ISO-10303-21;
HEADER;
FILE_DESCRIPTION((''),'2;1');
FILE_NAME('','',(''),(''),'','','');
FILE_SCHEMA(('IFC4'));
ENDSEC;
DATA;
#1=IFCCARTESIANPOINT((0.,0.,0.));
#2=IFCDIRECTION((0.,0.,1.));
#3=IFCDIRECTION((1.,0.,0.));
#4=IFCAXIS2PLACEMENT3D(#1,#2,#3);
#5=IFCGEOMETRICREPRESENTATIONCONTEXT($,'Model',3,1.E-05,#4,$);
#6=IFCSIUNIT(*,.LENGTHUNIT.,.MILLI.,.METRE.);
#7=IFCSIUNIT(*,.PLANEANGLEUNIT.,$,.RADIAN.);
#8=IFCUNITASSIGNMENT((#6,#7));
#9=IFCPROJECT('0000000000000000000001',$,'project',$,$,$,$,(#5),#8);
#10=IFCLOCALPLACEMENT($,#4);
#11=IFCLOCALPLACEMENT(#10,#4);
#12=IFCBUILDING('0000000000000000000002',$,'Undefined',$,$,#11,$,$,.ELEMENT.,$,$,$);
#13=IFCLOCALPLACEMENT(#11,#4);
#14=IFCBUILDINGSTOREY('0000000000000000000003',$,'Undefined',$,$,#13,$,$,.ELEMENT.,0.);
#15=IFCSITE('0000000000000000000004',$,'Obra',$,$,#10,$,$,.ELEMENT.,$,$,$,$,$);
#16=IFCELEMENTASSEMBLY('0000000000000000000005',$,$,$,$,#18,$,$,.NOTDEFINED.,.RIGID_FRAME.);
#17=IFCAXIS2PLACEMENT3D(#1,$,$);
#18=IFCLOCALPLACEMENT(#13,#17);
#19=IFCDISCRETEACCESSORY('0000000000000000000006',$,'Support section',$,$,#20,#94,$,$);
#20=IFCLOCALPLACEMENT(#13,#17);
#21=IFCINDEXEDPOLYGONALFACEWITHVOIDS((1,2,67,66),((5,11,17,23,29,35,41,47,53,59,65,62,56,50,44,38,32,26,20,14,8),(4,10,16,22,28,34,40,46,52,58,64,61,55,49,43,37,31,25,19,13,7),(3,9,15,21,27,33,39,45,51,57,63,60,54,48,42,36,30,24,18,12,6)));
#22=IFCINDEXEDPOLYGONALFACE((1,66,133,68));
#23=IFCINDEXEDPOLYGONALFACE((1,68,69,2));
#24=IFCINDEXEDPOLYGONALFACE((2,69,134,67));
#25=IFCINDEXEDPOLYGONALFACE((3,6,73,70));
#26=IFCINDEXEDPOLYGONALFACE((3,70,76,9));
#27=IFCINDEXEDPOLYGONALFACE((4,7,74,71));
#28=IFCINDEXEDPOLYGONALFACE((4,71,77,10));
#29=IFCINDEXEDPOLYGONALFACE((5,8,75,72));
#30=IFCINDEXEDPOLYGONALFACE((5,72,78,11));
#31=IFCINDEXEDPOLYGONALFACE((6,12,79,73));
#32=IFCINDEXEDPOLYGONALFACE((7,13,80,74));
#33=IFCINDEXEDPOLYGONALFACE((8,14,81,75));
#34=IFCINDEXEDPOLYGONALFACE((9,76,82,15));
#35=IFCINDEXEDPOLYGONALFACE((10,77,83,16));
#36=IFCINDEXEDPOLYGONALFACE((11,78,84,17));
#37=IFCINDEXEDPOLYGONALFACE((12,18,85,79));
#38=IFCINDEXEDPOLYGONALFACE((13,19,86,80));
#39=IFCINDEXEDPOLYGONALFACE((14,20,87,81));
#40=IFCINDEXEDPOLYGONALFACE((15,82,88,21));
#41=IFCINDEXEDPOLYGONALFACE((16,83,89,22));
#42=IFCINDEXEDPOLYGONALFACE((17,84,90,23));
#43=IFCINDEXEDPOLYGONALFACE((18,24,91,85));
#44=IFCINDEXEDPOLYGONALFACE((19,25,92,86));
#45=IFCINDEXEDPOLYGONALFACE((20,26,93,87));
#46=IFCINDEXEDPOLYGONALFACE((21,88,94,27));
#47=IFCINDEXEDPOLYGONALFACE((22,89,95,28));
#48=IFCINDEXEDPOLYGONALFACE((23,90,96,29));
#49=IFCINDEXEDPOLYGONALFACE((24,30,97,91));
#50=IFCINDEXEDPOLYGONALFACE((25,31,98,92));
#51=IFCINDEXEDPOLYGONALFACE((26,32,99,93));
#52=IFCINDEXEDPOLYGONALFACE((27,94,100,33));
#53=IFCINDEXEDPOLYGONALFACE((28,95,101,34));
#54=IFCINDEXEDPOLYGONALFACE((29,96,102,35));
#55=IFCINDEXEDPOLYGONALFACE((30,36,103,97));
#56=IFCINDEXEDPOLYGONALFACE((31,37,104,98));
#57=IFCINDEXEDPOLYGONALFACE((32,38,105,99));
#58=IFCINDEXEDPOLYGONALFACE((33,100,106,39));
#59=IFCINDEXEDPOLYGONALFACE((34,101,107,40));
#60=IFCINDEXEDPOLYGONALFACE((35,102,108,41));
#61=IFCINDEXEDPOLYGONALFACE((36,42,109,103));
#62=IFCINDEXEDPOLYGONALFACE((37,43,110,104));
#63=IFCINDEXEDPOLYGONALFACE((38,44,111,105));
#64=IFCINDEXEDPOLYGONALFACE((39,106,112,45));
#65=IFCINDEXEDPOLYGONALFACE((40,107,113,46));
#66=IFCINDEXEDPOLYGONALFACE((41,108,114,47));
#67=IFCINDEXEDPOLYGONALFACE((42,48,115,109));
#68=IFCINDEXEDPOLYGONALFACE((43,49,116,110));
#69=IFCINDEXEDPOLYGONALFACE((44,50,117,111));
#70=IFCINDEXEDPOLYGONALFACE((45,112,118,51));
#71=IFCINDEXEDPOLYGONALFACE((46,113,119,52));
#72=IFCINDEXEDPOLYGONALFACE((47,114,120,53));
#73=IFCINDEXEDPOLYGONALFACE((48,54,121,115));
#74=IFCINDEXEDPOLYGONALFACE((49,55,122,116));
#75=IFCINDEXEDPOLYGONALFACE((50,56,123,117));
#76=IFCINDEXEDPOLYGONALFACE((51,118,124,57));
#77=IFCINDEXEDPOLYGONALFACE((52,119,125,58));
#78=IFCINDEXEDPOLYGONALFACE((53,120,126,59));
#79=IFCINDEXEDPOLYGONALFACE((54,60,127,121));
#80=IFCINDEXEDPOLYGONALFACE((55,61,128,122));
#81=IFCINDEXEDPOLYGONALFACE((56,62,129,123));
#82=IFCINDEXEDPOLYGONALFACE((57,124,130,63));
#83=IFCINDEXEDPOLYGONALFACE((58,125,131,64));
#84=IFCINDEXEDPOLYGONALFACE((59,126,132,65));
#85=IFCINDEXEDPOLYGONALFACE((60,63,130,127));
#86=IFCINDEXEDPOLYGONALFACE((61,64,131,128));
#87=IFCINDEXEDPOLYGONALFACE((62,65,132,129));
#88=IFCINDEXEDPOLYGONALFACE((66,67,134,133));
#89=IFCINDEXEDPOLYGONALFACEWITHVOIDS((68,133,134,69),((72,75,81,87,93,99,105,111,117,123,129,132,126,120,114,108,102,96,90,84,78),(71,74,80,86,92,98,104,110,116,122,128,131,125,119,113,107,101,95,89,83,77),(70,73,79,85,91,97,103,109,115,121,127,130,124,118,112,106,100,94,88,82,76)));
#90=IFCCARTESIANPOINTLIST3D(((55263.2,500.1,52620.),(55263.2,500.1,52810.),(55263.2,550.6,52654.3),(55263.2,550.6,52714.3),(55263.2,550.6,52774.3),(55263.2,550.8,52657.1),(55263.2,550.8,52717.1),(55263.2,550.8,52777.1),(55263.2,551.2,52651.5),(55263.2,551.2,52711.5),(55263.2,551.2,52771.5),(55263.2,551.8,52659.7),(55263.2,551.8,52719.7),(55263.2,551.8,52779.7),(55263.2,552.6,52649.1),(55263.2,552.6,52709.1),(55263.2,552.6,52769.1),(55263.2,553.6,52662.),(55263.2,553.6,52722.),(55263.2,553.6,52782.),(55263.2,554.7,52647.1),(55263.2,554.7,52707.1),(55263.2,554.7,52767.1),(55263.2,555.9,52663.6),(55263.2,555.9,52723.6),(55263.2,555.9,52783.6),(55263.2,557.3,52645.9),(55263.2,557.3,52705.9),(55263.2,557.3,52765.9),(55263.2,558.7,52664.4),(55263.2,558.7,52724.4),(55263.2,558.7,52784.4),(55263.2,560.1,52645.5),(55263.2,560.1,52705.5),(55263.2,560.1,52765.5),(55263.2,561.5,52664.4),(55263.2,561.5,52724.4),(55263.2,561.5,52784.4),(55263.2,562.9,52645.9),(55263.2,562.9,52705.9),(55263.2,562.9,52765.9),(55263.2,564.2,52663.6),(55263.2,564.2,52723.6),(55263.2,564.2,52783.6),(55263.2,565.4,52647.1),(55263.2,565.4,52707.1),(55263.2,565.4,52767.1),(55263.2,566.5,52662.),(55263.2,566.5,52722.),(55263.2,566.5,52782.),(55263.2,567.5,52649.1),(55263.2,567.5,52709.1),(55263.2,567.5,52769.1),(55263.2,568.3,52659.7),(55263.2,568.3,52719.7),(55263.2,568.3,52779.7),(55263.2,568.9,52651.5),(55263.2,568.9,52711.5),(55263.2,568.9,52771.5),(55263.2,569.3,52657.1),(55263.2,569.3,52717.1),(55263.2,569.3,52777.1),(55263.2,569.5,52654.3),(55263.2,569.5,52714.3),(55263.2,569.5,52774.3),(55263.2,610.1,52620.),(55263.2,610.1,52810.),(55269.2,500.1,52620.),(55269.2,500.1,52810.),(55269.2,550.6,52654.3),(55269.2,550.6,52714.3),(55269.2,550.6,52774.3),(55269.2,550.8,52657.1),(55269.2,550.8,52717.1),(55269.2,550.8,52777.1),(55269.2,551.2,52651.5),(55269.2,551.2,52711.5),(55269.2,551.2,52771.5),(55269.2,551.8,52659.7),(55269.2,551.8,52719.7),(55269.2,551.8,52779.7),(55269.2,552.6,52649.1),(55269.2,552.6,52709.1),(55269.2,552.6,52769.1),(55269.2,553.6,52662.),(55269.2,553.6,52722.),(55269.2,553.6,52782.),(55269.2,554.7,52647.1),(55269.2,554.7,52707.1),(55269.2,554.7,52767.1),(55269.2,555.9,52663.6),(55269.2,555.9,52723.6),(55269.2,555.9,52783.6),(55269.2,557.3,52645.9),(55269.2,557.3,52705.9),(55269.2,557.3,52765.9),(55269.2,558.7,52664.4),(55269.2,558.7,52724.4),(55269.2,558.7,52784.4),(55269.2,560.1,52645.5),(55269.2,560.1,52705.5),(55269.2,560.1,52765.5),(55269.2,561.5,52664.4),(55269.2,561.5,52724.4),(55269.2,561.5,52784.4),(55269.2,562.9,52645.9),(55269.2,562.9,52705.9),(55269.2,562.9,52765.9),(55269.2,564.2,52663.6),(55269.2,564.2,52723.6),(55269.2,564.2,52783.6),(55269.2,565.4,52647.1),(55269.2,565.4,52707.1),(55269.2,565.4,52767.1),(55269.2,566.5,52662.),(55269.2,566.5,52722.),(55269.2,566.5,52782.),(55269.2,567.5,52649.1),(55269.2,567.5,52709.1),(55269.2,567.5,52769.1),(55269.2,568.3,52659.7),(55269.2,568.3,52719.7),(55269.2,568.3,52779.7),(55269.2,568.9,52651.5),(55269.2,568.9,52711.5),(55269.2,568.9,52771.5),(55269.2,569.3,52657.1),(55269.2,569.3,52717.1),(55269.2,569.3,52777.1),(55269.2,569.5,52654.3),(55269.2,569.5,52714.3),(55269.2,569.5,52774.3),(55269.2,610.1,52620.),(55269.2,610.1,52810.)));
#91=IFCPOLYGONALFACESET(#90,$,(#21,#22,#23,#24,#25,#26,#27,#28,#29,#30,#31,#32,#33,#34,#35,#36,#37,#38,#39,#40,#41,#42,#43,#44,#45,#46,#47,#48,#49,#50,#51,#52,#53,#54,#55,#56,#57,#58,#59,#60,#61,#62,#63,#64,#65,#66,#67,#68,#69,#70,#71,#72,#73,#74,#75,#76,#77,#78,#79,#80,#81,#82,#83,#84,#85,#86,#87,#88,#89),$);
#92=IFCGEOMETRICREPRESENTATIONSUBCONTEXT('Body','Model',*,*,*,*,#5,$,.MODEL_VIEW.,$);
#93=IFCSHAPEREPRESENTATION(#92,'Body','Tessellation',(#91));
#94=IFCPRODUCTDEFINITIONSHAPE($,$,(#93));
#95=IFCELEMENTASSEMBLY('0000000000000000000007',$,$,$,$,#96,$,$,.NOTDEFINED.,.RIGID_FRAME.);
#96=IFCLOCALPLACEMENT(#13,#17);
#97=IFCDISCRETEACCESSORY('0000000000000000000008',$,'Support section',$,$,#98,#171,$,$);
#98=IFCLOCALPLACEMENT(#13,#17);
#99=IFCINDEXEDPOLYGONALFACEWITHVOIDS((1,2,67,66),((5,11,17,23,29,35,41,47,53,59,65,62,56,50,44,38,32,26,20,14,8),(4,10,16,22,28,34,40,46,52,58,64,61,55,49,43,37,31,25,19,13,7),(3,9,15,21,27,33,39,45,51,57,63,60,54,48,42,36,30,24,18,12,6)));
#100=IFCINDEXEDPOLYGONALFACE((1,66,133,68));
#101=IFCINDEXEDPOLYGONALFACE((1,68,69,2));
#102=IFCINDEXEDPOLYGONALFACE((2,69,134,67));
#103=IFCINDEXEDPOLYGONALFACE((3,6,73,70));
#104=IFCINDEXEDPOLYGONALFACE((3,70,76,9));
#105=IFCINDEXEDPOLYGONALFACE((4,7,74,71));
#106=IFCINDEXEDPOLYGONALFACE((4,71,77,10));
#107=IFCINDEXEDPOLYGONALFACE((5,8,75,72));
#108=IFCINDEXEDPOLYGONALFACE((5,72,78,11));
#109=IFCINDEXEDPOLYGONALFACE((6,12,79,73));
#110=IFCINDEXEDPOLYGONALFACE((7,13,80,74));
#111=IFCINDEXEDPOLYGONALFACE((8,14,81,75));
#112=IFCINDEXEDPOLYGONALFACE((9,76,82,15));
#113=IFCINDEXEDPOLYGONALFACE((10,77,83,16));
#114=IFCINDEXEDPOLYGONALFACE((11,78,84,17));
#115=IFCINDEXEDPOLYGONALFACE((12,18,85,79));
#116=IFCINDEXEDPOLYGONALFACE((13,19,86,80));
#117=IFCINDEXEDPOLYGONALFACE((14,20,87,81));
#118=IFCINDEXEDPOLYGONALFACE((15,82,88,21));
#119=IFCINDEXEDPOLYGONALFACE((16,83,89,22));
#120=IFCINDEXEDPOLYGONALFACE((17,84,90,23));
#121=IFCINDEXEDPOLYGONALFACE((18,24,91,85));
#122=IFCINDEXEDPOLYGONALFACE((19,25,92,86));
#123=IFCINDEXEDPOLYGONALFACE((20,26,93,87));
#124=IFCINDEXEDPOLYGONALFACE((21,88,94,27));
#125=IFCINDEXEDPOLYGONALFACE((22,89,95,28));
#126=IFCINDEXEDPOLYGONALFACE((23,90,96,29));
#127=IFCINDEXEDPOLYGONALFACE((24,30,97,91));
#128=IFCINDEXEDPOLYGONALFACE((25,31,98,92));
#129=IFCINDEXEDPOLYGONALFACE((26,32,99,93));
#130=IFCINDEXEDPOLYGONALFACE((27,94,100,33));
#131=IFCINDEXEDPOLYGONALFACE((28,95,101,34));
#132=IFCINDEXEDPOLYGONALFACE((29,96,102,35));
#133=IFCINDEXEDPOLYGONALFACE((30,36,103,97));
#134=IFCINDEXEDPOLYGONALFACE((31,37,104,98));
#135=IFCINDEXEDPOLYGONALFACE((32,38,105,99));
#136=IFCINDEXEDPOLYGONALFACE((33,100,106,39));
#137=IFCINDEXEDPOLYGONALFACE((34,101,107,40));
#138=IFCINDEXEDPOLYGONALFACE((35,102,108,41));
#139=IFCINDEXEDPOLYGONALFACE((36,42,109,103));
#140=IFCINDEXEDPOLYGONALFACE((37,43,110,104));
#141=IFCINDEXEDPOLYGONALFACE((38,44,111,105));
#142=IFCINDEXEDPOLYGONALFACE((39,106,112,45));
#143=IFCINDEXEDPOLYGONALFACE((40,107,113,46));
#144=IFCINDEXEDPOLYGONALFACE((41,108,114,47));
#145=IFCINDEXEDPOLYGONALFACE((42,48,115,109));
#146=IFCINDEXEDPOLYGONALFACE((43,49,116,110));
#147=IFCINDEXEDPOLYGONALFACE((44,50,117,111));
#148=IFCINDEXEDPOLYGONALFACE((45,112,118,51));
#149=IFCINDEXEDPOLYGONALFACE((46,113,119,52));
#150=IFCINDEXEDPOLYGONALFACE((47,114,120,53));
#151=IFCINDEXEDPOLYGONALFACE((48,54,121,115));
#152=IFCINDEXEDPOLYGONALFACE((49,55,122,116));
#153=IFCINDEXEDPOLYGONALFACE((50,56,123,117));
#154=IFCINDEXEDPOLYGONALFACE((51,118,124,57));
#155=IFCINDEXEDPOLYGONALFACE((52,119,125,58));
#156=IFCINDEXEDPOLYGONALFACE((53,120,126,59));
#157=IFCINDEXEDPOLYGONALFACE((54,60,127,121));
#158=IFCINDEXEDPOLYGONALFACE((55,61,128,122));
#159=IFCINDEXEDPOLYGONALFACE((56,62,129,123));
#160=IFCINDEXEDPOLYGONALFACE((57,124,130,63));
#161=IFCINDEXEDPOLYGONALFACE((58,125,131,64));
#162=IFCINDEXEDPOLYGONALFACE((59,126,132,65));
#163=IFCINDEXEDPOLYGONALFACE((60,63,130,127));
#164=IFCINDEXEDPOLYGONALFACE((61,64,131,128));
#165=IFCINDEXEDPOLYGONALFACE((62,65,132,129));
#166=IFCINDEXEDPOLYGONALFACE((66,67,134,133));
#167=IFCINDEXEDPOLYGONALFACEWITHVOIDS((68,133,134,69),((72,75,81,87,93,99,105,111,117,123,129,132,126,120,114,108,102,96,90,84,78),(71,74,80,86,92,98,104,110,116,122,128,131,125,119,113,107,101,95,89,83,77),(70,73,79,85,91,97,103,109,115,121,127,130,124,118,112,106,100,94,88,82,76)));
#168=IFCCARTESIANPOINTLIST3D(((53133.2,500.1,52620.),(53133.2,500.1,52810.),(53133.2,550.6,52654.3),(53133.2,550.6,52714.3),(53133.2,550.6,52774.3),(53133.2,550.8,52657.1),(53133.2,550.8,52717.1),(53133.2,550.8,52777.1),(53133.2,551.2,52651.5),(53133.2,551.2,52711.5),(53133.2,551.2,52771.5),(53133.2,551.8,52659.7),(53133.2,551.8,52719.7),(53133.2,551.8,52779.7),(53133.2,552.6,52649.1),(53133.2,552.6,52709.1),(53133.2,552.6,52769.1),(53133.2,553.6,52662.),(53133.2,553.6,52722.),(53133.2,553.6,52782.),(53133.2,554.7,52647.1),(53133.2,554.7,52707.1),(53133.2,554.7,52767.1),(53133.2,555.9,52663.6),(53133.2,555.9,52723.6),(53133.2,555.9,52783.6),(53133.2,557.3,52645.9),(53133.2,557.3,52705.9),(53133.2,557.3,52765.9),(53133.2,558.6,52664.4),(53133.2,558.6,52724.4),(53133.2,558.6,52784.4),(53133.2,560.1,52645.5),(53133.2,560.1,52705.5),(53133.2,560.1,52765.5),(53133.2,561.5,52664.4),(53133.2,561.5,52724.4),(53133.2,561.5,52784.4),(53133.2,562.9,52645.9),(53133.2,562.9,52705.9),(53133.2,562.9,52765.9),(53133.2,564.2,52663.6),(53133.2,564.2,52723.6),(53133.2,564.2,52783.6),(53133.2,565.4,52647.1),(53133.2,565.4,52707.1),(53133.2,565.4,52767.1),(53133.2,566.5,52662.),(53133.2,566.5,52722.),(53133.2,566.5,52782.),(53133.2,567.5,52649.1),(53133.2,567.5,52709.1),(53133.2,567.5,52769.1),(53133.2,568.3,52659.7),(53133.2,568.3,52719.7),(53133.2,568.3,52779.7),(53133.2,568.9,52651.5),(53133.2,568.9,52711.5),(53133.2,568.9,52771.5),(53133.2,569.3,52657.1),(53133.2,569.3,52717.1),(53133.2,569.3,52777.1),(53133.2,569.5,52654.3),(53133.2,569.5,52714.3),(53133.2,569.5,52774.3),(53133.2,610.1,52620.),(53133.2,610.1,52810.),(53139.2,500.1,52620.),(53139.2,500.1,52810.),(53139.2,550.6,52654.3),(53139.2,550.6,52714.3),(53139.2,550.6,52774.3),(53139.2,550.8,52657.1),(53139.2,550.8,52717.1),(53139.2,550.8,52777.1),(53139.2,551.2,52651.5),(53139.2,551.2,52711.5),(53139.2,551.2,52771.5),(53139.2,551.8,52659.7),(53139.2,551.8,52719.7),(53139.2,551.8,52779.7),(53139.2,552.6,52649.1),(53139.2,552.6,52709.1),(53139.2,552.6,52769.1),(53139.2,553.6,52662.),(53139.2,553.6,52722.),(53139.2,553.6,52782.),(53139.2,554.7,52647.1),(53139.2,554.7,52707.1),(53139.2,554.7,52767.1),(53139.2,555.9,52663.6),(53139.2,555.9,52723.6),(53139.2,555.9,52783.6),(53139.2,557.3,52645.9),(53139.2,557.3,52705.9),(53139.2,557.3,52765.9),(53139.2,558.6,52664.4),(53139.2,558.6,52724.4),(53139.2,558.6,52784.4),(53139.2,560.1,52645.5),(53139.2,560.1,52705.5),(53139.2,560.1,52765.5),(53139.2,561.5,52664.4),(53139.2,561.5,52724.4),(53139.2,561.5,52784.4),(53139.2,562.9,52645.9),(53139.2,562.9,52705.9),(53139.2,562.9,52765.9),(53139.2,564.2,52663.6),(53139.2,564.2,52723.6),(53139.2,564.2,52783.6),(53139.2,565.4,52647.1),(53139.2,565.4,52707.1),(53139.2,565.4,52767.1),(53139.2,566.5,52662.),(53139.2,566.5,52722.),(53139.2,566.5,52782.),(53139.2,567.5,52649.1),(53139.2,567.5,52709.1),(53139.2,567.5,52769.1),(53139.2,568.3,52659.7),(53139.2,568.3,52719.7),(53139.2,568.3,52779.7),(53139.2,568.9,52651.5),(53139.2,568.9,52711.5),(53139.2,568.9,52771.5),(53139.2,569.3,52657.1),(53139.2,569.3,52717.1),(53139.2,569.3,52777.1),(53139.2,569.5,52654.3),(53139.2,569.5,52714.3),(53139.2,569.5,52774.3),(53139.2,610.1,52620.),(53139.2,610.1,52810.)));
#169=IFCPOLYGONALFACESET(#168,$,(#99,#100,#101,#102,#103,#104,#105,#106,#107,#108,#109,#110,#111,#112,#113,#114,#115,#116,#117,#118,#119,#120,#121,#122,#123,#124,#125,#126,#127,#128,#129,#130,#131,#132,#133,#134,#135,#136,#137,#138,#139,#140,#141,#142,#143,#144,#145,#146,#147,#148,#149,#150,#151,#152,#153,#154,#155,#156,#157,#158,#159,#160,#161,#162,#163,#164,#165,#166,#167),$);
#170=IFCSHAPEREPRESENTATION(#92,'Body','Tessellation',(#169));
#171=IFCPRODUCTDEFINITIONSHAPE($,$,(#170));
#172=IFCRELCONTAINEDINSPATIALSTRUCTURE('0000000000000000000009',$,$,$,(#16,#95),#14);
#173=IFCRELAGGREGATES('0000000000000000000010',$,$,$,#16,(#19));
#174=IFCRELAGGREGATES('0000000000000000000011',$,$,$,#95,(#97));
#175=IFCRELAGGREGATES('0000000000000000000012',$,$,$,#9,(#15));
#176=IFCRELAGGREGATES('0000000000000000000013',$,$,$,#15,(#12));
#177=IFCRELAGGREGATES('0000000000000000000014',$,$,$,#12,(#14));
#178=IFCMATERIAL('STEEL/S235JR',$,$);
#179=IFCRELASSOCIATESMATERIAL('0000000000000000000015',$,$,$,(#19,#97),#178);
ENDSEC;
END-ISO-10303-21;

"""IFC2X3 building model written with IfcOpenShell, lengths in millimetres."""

from ifc_helpers import new_model, si_unit, frame, origin_with_axes, origin_2d_with_axis, place, context, subcontext, project, spatial, rectangle, circle, extrude, source, transform, mapped, material, element, aggregate, save


model = new_model("IFC2X3")

# Units and contexts
model_context = context("Model", 3, precision=1e-05, world=origin_with_axes())
body_context = subcontext(model_context, "Body", "Model", "MODEL_VIEW")
ifc_project = project(units=[si_unit("LENGTHUNIT", "METRE", prefix="MILLI"), si_unit("PLANEANGLEUNIT", "RADIAN")], contexts=[model_context])

# Site, building, storey
site_placement = place(None, origin_with_axes())
site = spatial("IfcSite", under=ifc_project, at=site_placement, Name="Obra", CompositionType="ELEMENT")
building_placement = place(site_placement, origin_with_axes())
building = spatial("IfcBuilding", under=site, at=building_placement, Name="Undefined", CompositionType="ELEMENT")
storey_placement = place(building_placement, origin_with_axes())
storey = spatial("IfcBuildingStorey", under=building, at=storey_placement, Name="Undefined", CompositionType="ELEMENT", Elevation=0.0)

# Shared definitions
ifc_material_1 = material(Name="STEEL/S235JR")

# Shared definitions
shared_shape_1 = source(origin_with_axes(), body_context, "Body", "SweptSolid", [
    extrude(circle(Radius=9.5, at=origin_2d_with_axis()), frame((0.0, -9.2, 0.0), z_axis=(0.0, 1.0, 0.0), x_axis=(1.0, 0.0, 0.0)), (0.0, 0.0, 1.0), 6.2),
])

# Element assemblies, discrete accessories, openings
assembly_1_placement = place(storey_placement, origin_with_axes())
assembly_1 = element("IfcElementAssembly", 1, at=assembly_1_placement, inside=storey, AssemblyPlace="NOTDEFINED", PredefinedType="RIGID_FRAME")
discrete_accessory_1_placement = place(assembly_1_placement, frame((55266.2, 555.1, 52620.0), z_axis=(0.0, 0.0, 1.0), x_axis=(0.000002, -1.0, 0.0)))
discrete_accessory_1 = element("IfcDiscreteAccessory", 2, at=discrete_accessory_1_placement, material=ifc_material_1, Name="Support section", context=body_context, shape_type="SweptSolid", body=[
    extrude(rectangle(XDim=6.0, YDim=110.0, at=origin_2d_with_axis()), frame((0.0, 0.0, 190.0), z_axis=(0.0, 0.0, -1.0), x_axis=(0.0, 1.0, 0.0)), (0.0, 0.0, 1.0), 190.0),
])
opening_1_placement = place(assembly_1_placement, frame((55260.1, 510.1, 52835.0), z_axis=(-0.000002, 1.0, 0.0), x_axis=(0.0, 0.0, -1.0)))
element("IfcOpeningElement", 3, at=opening_1_placement, cuts=discrete_accessory_1, ObjectType="Opening", context=body_context, shape_type="MappedRepresentation", body=[
    mapped(shared_shape_1, transform((60.0, 0.0, 50.0))),
    mapped(shared_shape_1, transform((120.0, 0.0, 50.0))),
    mapped(shared_shape_1, transform((180.0, 0.0, 50.0))),
])
aggregate(assembly_1, [discrete_accessory_1])
assembly_2_placement = place(storey_placement, origin_with_axes())
assembly_2 = element("IfcElementAssembly", 4, at=assembly_2_placement, inside=storey, AssemblyPlace="NOTDEFINED", PredefinedType="RIGID_FRAME")
discrete_accessory_2_placement = place(assembly_2_placement, frame((53136.2, 555.1, 52620.0), z_axis=(0.0, 0.0, 1.0), x_axis=(0.000002, -1.0, 0.0)))
discrete_accessory_2 = element("IfcDiscreteAccessory", 5, at=discrete_accessory_2_placement, material=ifc_material_1, Name="Support section", context=body_context, shape_type="SweptSolid", body=[
    extrude(rectangle(XDim=6.0, YDim=110.0, at=origin_2d_with_axis()), frame((0.0, 0.0, 190.0), z_axis=(0.0, 0.0, -1.0), x_axis=(0.0, 1.0, 0.0)), (0.0, 0.0, 1.0), 190.0),
])
opening_2_placement = place(assembly_2_placement, frame((53130.1, 510.1, 52835.0), z_axis=(-0.000002, 1.0, 0.0), x_axis=(0.0, 0.0, -1.0)))
element("IfcOpeningElement", 6, at=opening_2_placement, cuts=discrete_accessory_2, ObjectType="Opening", context=body_context, shape_type="MappedRepresentation", body=[
    mapped(shared_shape_1, transform((60.0, 0.0, 50.0))),
    mapped(shared_shape_1, transform((120.0, 0.0, 50.0))),
    mapped(shared_shape_1, transform((180.0, 0.0, 50.0))),
])
aggregate(assembly_2, [discrete_accessory_2])

save(model, "model.ifc")
